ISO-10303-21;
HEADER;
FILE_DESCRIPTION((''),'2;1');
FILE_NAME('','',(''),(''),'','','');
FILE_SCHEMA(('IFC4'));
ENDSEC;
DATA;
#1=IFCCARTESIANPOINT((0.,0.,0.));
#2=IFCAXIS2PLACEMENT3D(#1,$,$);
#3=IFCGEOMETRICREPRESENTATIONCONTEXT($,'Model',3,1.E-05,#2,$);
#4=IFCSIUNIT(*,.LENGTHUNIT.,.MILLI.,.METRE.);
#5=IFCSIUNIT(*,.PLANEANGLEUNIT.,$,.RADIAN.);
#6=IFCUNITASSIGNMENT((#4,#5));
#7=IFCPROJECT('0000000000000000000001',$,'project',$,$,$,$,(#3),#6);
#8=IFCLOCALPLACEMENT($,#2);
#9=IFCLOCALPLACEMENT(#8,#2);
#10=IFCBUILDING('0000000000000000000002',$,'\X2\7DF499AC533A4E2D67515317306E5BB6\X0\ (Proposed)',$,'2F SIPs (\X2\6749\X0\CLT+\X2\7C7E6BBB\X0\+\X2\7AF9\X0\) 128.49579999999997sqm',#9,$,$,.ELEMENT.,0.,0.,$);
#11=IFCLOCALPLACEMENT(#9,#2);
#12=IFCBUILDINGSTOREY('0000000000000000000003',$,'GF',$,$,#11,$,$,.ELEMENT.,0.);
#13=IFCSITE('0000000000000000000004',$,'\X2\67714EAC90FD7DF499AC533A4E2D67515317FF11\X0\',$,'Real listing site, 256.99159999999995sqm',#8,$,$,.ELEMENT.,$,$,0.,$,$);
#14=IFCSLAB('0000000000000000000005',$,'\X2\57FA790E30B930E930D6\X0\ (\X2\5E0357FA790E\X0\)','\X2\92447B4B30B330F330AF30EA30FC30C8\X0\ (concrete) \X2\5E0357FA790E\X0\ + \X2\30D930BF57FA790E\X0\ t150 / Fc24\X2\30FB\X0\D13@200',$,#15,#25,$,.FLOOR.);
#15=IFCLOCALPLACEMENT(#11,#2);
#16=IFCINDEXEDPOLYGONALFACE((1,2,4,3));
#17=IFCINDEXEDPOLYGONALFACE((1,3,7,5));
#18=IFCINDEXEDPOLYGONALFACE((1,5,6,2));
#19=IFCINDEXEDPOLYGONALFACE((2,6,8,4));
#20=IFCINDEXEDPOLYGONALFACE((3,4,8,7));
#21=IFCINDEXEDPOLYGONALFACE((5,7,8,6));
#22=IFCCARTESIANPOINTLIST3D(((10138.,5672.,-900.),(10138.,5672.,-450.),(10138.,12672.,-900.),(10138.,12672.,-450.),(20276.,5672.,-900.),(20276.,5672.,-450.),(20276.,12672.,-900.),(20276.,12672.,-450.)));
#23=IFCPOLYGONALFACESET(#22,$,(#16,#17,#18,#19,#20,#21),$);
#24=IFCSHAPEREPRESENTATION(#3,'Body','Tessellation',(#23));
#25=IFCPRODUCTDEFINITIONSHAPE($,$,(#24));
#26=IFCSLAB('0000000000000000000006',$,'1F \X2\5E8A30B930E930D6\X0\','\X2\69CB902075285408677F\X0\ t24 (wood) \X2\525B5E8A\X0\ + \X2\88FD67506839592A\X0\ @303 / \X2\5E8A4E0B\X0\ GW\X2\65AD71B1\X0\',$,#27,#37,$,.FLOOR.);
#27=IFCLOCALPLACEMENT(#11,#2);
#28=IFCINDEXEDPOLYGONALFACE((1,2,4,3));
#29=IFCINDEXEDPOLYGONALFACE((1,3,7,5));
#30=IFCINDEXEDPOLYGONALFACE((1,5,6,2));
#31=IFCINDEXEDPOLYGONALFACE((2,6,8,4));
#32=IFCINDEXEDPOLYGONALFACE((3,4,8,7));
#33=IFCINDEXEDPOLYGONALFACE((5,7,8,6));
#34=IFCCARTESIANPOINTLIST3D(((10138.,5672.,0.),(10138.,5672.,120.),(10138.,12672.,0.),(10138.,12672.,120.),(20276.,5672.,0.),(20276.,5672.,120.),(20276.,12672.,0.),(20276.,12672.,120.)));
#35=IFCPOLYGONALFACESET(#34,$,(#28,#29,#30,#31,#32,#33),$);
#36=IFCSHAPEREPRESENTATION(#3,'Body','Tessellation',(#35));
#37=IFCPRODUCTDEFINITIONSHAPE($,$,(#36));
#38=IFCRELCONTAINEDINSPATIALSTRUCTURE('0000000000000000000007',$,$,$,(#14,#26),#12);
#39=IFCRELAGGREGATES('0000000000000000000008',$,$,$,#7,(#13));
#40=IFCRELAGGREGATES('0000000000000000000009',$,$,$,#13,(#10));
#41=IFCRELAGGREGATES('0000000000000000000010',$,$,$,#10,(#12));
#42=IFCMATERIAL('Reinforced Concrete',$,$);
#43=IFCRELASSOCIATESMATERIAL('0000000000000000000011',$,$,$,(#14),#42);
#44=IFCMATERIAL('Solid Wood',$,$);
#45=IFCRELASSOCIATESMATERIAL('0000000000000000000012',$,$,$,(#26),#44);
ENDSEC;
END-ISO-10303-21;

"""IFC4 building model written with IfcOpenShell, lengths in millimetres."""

from ifc_helpers import new_model, si_unit, frame, frame_2d, origin, place, context, project, spatial, rectangle, extrude, material, element, save


model = new_model("IFC4")

# Units and contexts
model_context = context("Model", 3, precision=1e-05, world=origin())
ifc_project = project(units=[si_unit("LENGTHUNIT", "METRE", prefix="MILLI"), si_unit("PLANEANGLEUNIT", "RADIAN")], contexts=[model_context])

# Site, building, storey
site_placement = place(None, origin())
site = spatial("IfcSite", under=ifc_project, at=site_placement, Name="東京都練馬区中村北１", ObjectType="Real listing site, 256.99159999999995sqm", CompositionType="ELEMENT", RefElevation=0.0)
building_placement = place(site_placement, origin())
building = spatial("IfcBuilding", under=site, at=building_placement, Name="練馬区中村北の家 (Proposed)", ObjectType="2F SIPs (杉CLT+籾殻+竹) 128.49579999999997sqm", CompositionType="ELEMENT", ElevationOfRefHeight=0.0, ElevationOfTerrain=0.0)
storey_placement = place(building_placement, origin())
storey = spatial("IfcBuildingStorey", under=building, at=storey_placement, Name="GF", CompositionType="ELEMENT", Elevation=0.0)

# Slabs
ifc_material_1 = material(Name="Reinforced Concrete")
slab_1_placement = place(storey_placement, frame((5069.0, 2836.0, -450.0)))
element("IfcSlab", 1, at=slab_1_placement, inside=storey, material=ifc_material_1, Name="基礎スラブ (布基礎)", Description="鉄筋コンクリート (concrete) 布基礎 + ベタ基礎 t150 / Fc24・D13@200", PredefinedType="FLOOR", context=model_context, shape_type="SweptSolid", body=[
    extrude(rectangle(XDim=10138.0, YDim=7000.0, at=frame_2d((5069.0, 3500.0))), frame((5069.0, 2836.0, -450.0)), (0.0, 0.0, 1.0), 450.0),
])
ifc_material_2 = material(Name="Solid Wood")
slab_2_placement = place(storey_placement, frame((5069.0, 2836.0, 0.0)))
element("IfcSlab", 2, at=slab_2_placement, inside=storey, material=ifc_material_2, Name="1F 床スラブ", Description="構造用合板 t24 (wood) 剛床 + 製材根太 @303 / 床下 GW断熱", PredefinedType="FLOOR", context=model_context, shape_type="SweptSolid", body=[
    extrude(rectangle(XDim=10138.0, YDim=7000.0, at=frame_2d((5069.0, 3500.0))), frame((5069.0, 2836.0, 0.0)), (0.0, 0.0, 1.0), 120.0),
])

save(model, "model.ifc")
